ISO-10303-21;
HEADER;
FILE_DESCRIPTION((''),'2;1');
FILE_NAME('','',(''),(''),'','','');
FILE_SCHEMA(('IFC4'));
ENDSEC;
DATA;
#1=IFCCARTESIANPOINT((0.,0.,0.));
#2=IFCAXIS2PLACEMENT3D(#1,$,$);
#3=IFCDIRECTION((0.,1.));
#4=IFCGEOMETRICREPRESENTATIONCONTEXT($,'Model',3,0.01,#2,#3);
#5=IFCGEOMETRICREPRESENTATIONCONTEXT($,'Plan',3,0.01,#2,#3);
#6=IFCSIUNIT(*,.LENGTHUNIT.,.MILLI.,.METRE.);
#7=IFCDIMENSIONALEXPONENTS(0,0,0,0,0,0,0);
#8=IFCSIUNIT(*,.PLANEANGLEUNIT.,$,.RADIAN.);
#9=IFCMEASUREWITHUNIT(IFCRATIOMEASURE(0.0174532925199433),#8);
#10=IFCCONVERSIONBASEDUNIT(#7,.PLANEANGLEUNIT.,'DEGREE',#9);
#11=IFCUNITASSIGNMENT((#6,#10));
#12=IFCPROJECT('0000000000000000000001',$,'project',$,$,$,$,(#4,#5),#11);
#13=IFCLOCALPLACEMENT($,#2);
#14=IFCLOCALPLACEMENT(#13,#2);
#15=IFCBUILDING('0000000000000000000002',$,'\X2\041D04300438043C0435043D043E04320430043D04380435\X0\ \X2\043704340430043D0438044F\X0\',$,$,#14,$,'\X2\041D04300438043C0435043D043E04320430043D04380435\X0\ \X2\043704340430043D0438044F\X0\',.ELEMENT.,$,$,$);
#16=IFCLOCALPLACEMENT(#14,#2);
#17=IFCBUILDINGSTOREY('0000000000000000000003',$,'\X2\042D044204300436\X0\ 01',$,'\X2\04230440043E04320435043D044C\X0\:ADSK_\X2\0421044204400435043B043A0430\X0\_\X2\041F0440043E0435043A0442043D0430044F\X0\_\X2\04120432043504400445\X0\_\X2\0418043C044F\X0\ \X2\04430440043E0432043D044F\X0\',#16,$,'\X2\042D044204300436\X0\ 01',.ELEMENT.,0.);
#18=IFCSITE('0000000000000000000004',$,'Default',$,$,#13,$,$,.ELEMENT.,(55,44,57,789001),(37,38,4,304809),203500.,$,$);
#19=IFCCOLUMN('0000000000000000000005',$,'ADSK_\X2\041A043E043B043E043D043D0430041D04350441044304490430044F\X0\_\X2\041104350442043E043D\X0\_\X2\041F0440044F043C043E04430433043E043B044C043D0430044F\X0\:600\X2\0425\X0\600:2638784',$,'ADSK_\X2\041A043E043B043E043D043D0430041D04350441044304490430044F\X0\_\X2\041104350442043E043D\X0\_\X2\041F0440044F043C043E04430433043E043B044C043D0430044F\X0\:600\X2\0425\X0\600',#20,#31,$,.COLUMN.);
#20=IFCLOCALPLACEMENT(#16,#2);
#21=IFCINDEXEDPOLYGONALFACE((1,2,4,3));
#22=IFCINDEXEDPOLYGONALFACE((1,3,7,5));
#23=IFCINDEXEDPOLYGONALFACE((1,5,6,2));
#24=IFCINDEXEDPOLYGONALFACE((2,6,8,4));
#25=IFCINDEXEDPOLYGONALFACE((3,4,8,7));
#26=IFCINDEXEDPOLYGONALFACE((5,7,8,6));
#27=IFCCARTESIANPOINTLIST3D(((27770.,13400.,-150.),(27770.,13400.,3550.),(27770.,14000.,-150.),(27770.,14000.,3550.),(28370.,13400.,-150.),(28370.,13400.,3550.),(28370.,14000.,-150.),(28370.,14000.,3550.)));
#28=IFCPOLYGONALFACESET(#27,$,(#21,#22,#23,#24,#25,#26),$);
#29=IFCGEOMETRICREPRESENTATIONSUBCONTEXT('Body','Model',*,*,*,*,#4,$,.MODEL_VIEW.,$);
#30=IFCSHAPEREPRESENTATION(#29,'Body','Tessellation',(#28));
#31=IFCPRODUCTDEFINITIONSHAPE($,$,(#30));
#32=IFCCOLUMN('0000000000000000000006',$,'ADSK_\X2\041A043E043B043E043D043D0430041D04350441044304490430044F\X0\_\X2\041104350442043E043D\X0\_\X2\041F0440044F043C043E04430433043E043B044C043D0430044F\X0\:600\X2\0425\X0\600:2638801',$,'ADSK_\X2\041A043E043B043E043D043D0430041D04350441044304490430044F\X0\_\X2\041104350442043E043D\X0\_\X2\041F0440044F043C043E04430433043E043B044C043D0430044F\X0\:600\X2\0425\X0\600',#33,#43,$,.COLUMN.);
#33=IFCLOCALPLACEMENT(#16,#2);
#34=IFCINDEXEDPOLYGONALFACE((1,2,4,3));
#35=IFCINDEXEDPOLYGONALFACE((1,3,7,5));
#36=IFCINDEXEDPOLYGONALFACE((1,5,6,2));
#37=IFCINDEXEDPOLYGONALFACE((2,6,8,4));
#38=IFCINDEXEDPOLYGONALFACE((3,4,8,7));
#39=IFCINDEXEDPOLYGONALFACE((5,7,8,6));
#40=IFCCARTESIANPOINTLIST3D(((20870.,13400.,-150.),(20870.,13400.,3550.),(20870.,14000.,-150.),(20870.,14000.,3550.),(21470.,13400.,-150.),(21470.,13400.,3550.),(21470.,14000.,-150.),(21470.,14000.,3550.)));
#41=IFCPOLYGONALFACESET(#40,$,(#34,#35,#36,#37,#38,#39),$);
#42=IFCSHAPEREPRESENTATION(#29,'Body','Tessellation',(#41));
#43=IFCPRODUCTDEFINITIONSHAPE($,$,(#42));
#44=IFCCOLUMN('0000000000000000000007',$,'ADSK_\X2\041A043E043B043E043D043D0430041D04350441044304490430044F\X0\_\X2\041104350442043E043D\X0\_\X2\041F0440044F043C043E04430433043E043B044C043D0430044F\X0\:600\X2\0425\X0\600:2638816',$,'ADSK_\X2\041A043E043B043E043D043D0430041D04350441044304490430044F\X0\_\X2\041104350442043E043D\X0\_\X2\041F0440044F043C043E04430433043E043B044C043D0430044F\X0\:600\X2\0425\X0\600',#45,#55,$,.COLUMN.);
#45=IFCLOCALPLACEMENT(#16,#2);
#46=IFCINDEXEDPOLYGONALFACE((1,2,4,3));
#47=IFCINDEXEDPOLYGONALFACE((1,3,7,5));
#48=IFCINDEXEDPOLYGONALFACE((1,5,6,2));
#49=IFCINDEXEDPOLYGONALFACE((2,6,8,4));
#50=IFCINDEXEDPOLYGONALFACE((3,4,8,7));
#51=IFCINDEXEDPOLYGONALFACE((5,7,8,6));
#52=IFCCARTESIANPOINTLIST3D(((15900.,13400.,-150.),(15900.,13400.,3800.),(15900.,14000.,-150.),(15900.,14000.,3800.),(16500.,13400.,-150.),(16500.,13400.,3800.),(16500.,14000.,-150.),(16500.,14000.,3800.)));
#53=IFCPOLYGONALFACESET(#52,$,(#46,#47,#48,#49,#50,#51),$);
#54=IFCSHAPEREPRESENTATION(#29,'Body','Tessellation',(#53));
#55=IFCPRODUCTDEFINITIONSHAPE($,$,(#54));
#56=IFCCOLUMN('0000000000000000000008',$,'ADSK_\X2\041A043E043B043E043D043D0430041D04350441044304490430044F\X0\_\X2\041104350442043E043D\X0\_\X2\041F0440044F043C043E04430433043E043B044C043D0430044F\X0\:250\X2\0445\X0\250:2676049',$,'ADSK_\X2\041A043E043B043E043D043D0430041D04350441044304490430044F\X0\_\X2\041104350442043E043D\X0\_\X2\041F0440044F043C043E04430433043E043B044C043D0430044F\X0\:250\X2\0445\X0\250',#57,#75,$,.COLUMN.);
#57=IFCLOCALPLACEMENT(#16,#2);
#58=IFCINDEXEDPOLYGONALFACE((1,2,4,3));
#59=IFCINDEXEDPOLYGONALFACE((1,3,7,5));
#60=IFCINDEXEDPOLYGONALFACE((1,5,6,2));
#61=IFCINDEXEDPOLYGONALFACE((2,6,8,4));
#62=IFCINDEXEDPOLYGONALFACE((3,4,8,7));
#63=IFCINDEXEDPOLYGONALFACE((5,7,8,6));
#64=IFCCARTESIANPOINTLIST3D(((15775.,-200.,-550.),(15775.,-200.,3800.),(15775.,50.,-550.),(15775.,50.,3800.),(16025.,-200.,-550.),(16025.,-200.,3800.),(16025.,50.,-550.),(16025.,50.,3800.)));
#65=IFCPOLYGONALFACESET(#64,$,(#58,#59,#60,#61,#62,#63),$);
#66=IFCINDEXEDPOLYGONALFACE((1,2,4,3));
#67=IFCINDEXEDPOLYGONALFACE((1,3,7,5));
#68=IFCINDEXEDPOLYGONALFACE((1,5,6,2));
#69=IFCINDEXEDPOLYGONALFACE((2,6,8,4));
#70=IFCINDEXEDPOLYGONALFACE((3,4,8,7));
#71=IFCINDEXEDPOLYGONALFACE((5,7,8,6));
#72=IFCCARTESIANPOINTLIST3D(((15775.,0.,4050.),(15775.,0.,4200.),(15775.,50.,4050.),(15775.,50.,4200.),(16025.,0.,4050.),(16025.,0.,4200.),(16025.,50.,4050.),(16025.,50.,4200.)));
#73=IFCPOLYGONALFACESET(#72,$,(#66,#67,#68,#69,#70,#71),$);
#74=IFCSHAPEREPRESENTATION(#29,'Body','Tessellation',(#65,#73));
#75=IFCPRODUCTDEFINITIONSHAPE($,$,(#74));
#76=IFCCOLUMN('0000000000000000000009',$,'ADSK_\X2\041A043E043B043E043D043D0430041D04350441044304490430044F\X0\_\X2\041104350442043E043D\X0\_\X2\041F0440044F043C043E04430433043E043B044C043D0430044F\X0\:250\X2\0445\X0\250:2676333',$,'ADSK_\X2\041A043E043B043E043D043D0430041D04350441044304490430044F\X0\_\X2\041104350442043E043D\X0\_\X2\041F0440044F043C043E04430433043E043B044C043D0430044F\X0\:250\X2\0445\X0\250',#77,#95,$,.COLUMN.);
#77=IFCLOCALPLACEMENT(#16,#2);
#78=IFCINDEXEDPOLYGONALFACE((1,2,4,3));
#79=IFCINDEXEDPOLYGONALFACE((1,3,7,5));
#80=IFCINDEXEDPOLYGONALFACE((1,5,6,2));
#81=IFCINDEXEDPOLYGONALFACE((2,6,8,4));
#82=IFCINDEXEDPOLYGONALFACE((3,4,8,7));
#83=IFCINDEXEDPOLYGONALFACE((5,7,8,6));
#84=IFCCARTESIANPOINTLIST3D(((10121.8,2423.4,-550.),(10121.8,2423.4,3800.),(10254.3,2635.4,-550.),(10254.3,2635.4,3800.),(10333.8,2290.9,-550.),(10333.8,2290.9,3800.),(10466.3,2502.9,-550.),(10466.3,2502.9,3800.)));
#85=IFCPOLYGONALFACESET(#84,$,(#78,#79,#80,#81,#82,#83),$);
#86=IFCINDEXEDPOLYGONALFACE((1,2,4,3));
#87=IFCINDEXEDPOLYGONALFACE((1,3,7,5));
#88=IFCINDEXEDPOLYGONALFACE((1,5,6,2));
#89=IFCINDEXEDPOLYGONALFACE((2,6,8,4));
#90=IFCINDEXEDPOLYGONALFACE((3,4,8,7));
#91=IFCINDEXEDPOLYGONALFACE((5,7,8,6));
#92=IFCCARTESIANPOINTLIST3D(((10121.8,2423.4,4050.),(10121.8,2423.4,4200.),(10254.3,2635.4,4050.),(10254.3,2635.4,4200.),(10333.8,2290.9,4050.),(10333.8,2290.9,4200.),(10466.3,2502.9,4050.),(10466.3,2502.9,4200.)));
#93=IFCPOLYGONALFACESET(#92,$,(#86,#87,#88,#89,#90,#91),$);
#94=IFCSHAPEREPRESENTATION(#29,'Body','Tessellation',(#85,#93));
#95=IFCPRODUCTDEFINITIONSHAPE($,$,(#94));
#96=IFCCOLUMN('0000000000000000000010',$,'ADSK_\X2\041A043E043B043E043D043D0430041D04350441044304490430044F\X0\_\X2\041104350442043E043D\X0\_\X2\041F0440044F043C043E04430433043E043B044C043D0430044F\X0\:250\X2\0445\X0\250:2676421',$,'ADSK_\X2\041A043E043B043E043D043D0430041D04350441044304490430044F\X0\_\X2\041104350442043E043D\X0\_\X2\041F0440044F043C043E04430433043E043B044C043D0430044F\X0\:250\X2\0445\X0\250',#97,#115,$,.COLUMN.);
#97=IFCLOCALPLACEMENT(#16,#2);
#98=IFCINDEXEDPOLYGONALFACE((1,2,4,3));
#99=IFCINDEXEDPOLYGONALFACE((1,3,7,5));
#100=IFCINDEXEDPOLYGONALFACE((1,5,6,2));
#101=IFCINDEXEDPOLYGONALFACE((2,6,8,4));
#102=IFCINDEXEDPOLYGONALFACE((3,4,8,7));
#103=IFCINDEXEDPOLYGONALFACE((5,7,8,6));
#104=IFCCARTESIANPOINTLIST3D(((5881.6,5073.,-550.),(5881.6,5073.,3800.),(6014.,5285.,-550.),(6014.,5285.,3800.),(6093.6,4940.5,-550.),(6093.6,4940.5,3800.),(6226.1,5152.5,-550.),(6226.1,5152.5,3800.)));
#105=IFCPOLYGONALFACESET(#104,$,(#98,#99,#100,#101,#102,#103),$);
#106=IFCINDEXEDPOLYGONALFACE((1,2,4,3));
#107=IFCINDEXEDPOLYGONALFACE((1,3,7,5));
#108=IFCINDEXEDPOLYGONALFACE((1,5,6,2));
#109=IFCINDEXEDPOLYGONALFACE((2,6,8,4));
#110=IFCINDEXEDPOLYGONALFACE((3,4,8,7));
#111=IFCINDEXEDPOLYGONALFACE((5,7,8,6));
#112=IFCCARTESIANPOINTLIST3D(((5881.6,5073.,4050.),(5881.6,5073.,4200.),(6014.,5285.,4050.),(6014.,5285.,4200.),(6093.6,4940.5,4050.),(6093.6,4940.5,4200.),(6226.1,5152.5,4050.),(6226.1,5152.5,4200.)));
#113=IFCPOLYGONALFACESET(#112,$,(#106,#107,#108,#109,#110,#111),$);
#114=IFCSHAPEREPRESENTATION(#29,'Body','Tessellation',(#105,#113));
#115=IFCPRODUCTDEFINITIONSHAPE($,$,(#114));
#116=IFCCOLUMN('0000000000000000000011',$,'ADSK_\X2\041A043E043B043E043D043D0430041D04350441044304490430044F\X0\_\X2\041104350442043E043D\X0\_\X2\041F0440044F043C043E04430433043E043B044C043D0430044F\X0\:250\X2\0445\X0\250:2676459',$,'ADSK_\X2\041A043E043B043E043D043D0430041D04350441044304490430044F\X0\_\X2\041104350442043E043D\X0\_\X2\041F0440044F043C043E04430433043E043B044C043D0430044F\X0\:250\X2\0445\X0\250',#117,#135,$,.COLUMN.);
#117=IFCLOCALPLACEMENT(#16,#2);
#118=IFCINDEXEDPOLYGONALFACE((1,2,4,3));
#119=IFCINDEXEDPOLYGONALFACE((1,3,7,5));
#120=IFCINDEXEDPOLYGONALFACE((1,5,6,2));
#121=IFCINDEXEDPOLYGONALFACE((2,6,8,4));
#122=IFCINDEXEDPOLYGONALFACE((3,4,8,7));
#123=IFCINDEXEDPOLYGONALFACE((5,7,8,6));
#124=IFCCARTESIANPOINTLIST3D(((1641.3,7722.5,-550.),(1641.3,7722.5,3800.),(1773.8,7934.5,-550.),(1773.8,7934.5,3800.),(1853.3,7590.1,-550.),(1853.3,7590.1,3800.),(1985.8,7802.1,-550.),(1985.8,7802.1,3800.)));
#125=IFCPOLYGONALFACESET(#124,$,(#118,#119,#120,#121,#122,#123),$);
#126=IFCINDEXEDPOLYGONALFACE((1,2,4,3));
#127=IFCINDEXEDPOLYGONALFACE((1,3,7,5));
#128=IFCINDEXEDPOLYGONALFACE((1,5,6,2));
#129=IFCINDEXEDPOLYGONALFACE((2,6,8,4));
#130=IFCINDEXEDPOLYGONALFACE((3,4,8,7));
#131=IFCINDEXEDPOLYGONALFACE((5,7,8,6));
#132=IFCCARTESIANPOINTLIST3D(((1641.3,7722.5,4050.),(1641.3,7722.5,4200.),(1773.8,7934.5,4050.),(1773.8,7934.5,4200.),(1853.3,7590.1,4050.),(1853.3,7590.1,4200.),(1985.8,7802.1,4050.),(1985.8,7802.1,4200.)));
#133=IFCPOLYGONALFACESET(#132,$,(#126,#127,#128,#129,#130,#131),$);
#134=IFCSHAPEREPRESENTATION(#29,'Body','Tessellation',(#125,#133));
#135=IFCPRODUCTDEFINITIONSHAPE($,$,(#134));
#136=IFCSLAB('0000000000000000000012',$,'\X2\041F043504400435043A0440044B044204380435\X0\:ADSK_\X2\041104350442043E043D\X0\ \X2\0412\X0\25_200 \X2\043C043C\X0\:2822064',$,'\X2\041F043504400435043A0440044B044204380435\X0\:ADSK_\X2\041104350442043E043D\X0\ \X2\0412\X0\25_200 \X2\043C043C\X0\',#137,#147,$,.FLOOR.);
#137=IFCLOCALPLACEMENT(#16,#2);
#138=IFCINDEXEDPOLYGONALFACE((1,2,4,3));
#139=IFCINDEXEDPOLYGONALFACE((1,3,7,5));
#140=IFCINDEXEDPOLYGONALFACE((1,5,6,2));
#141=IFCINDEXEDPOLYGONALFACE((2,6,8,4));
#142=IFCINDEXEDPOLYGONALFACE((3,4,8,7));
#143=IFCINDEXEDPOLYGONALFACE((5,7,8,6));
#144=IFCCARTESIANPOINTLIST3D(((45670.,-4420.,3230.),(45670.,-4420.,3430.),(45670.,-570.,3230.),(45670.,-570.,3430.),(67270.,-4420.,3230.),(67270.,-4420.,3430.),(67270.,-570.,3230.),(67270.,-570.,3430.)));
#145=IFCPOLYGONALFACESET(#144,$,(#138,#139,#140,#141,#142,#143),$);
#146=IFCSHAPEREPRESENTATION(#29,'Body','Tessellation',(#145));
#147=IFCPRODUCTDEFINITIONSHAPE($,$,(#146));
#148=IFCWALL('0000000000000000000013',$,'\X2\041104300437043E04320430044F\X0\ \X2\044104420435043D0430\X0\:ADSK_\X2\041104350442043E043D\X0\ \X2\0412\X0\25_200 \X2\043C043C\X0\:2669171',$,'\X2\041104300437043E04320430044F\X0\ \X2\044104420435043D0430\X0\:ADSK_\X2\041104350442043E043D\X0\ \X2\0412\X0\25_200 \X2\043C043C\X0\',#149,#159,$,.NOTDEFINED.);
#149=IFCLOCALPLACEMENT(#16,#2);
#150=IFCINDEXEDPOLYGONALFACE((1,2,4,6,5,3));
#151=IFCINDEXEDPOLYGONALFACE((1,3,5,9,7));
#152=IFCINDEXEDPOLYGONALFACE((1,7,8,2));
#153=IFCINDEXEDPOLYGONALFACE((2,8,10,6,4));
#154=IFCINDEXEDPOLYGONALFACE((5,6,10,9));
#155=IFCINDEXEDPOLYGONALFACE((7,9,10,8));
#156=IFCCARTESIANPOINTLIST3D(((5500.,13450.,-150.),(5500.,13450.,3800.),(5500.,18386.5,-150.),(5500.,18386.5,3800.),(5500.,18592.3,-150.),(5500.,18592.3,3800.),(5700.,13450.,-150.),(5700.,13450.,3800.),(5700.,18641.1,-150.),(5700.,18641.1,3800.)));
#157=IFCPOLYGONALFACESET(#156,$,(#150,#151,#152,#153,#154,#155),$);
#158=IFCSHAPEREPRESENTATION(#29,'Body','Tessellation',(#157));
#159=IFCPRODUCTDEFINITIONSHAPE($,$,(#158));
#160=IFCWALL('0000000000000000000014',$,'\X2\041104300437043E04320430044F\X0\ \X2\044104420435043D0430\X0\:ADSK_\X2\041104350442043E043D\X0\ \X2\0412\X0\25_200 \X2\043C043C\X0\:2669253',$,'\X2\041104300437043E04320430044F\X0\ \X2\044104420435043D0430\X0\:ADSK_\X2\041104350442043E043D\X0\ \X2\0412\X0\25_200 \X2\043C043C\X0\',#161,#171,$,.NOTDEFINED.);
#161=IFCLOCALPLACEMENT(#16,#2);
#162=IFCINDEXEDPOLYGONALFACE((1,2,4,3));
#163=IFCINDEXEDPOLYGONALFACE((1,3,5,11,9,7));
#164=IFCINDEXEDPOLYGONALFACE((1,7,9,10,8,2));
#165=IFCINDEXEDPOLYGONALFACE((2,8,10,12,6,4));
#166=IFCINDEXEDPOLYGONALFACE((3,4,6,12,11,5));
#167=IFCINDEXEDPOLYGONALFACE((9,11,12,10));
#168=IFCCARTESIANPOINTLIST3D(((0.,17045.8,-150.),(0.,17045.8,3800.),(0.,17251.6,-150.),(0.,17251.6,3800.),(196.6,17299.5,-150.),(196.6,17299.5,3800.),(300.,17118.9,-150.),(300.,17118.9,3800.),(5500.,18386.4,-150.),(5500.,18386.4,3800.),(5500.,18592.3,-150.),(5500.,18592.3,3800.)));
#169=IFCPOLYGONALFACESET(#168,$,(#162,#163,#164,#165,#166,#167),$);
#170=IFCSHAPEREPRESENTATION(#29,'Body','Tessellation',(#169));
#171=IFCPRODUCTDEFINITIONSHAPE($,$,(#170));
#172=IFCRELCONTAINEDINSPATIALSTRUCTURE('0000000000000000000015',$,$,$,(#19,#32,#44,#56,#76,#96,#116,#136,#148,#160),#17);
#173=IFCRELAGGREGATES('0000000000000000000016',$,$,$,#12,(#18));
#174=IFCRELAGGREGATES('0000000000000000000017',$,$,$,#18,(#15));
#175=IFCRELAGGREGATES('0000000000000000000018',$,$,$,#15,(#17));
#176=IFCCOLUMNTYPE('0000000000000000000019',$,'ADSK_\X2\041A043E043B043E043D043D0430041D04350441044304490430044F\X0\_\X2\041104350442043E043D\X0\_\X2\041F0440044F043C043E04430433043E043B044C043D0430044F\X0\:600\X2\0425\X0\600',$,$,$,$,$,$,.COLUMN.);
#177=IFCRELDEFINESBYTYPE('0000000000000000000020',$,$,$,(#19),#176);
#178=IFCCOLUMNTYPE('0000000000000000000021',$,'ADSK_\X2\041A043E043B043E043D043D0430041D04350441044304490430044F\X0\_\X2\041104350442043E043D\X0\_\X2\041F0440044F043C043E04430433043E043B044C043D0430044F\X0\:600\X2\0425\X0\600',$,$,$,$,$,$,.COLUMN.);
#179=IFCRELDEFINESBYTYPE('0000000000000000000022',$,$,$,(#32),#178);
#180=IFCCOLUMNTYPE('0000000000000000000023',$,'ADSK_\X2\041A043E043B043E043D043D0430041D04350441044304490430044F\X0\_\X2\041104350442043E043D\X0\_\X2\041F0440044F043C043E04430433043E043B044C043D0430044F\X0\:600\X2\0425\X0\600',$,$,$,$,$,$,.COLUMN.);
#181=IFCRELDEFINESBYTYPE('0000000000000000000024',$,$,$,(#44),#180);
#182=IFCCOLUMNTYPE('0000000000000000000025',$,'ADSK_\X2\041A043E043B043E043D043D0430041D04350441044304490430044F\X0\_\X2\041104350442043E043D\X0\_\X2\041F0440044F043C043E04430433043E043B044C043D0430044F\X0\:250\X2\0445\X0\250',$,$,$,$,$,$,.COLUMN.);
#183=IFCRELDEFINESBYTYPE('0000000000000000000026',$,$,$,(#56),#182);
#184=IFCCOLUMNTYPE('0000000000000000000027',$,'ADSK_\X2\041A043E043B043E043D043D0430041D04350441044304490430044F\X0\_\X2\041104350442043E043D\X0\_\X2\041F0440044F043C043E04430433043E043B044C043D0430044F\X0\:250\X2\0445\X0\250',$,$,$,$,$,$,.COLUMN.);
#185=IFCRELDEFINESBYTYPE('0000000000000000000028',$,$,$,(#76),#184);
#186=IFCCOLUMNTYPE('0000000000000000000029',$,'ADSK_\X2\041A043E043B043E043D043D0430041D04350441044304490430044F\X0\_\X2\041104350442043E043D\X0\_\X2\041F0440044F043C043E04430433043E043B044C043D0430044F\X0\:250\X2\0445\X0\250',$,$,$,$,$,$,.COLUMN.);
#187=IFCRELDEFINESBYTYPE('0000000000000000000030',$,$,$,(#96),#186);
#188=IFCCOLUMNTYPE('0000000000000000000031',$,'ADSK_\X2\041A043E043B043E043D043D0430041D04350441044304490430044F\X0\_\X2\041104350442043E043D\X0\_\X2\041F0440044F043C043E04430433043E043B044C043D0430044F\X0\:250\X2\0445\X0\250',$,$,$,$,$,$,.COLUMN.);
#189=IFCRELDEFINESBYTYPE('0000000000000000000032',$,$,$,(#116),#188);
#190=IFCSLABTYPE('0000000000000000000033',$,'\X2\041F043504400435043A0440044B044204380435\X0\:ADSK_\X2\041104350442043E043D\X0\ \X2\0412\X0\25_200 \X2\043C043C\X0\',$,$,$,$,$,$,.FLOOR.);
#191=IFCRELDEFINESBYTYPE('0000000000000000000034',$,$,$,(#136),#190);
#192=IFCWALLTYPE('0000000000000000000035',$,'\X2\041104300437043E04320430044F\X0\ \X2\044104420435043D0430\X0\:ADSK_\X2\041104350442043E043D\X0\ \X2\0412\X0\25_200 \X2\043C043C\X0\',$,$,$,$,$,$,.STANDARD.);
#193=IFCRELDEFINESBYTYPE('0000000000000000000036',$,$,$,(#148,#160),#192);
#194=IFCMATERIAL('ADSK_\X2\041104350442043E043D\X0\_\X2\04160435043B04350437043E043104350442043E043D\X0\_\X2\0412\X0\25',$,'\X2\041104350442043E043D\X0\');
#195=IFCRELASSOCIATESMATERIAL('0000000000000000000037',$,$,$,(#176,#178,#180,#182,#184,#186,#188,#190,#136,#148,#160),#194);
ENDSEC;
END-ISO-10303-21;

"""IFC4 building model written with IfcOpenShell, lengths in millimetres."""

from ifc_helpers import new_model, entity, si_unit, converted_unit, direction, frame, origin, place, context, subcontext, project, spatial, indexed_curve, outline, extrude, source, transform, mapped, material, type_object, type_shapes, element, save


model = new_model("IFC4")

# Units and contexts
model_context = context("Model", 3, precision=0.01, world=origin(), true_north=direction((0.0, 1.0)))
plan_context = context("Plan", 3, precision=0.01, world=origin(), true_north=direction((0.0, 1.0)))
body_context = subcontext(model_context, "Body", "Model", "MODEL_VIEW")
ifc_project = project(units=[si_unit("LENGTHUNIT", "METRE", prefix="MILLI"), converted_unit("PLANEANGLEUNIT", "DEGREE", entity("IfcRatioMeasure", 0.0174532925199433), si_unit("PLANEANGLEUNIT", "RADIAN"), dimensions=[0, 0, 0, 0, 0, 0, 0])], contexts=[model_context, plan_context])

# Site, building, storey
site_placement = place(None, origin())
site = spatial("IfcSite", under=ifc_project, at=site_placement, Name="Default", CompositionType="ELEMENT", RefLatitude=(55, 44, 57, 789001), RefLongitude=(37, 38, 4, 304809), RefElevation=203500.0)
building_placement = place(site_placement, origin())
building = spatial("IfcBuilding", under=site, at=building_placement, Name="Наименование здания", LongName="Наименование здания", CompositionType="ELEMENT")
storey_placement = place(building_placement, origin())
storey = spatial("IfcBuildingStorey", under=building, at=storey_placement, Name="Этаж 01", ObjectType="Уровень:ADSK_Стрелка_Проектная_Вверх_Имя уровня", LongName="Этаж 01", CompositionType="ELEMENT", Elevation=0.0)

# Columns
ifc_material = material(Name="ADSK_Бетон_Железобетон_В25", Category="Бетон")
placement = place(storey_placement, origin())
column_type_1 = type_object("IfcColumnType", Name="ADSK_КолоннаНесущая_Бетон_Прямоугольная:600Х600", PredefinedType="COLUMN", material=ifc_material)
shared_shape_1 = source(origin(), body_context, "Body", "SweptSolid", [
    extrude(outline(indexed_curve([(-300.0, -300.0), (300.0, -300.0), (300.0, 300.0), (-300.0, 300.0), (-300.0, -300.0)], self_intersect=False)), frame((28070.0, 13700.0, -150.0), z_axis=(0.0, 0.0, 1.0), x_axis=(0.0, -1.0, 0.0)), (0.0, 0.0, 1.0), 3700.0),
])
type_shapes(column_type_1, [shared_shape_1])
element("IfcColumn", 1, at=placement, inside=storey, type_object=column_type_1, Name="ADSK_КолоннаНесущая_Бетон_Прямоугольная:600Х600:2638784", ObjectType="ADSK_КолоннаНесущая_Бетон_Прямоугольная:600Х600", PredefinedType="COLUMN", context=body_context, shape_type="MappedRepresentation", body=[
    mapped(shared_shape_1, transform((0.0, 0.0, 0.0), scale=1.0)),
])
column_type_2 = type_object("IfcColumnType", Name="ADSK_КолоннаНесущая_Бетон_Прямоугольная:600Х600", PredefinedType="COLUMN", material=ifc_material)
shared_shape_2 = source(origin(), body_context, "Body", "SweptSolid", [
    extrude(outline(indexed_curve([(-300.0, -300.0), (300.0, -300.0), (300.0, 300.0), (-300.0, 300.0), (-300.0, -300.0)], self_intersect=False)), frame((21170.0, 13700.0, -150.0), z_axis=(0.0, 0.0, 1.0), x_axis=(0.0, -1.0, 0.0)), (0.0, 0.0, 1.0), 3700.0),
])
type_shapes(column_type_2, [shared_shape_2])
element("IfcColumn", 2, at=placement, inside=storey, type_object=column_type_2, Name="ADSK_КолоннаНесущая_Бетон_Прямоугольная:600Х600:2638801", ObjectType="ADSK_КолоннаНесущая_Бетон_Прямоугольная:600Х600", PredefinedType="COLUMN", context=body_context, shape_type="MappedRepresentation", body=[
    mapped(shared_shape_2, transform((0.0, 0.0, 0.0), scale=1.0)),
])
column_type_3 = type_object("IfcColumnType", Name="ADSK_КолоннаНесущая_Бетон_Прямоугольная:600Х600", PredefinedType="COLUMN", material=ifc_material)
shared_shape_3 = source(origin(), body_context, "Body", "SweptSolid", [
    extrude(outline(indexed_curve([(-300.0, -300.0), (300.0, -300.0), (300.0, 300.0), (-300.0, 300.0), (-300.0, -300.0)], self_intersect=False)), frame((16200.0, 13700.0, -150.0), z_axis=(0.0, 0.0, 1.0), x_axis=(0.0, -1.0, 0.0)), (0.0, 0.0, 1.0), 3950.0),
])
type_shapes(column_type_3, [shared_shape_3])
element("IfcColumn", 3, at=placement, inside=storey, type_object=column_type_3, Name="ADSK_КолоннаНесущая_Бетон_Прямоугольная:600Х600:2638816", ObjectType="ADSK_КолоннаНесущая_Бетон_Прямоугольная:600Х600", PredefinedType="COLUMN", context=body_context, shape_type="MappedRepresentation", body=[
    mapped(shared_shape_3, transform((0.0, 0.0, 0.0), scale=1.0)),
])
column_type_4 = type_object("IfcColumnType", Name="ADSK_КолоннаНесущая_Бетон_Прямоугольная:250х250", PredefinedType="COLUMN", material=ifc_material)
shared_shape_4 = source(origin(), body_context, "Body", "SweptSolid", [
    extrude(outline(indexed_curve([(-125.0, -125.0), (125.0, -125.0), (125.0, 125.0), (-125.0, 125.0), (-125.0, -125.0)], self_intersect=False)), frame((15900.0, -75.0, -550.0), z_axis=(0.0, 0.0, 1.0), x_axis=(0.0, -1.0, 0.0)), (0.0, 0.0, 1.0), 4350.0),
    extrude(outline(indexed_curve([(-25.0, -125.0), (25.0, -125.0), (25.0, 125.0), (-25.0, 125.0), (-25.0, -125.0)], self_intersect=False)), frame((15900.0, 25.0, 4050.0), z_axis=(0.0, 0.0, 1.0), x_axis=(0.0, -1.0, 0.0)), (0.0, 0.0, 1.0), 150.0),
])
type_shapes(column_type_4, [shared_shape_4])
element("IfcColumn", 4, at=placement, inside=storey, type_object=column_type_4, Name="ADSK_КолоннаНесущая_Бетон_Прямоугольная:250х250:2676049", ObjectType="ADSK_КолоннаНесущая_Бетон_Прямоугольная:250х250", PredefinedType="COLUMN", context=body_context, shape_type="MappedRepresentation", body=[
    mapped(shared_shape_4, transform((0.0, 0.0, 0.0), scale=1.0)),
])
column_type_5 = type_object("IfcColumnType", Name="ADSK_КолоннаНесущая_Бетон_Прямоугольная:250х250", PredefinedType="COLUMN", material=ifc_material)
shared_shape_5 = source(origin(), body_context, "Body", "SweptSolid", [
    extrude(outline(indexed_curve([(-125.0, -125.0), (125.0, -125.0), (125.0, 125.0), (-125.0, 125.0), (-125.0, -125.0)], self_intersect=False)), frame((10294.1, 2463.2, -550.0), z_axis=(0.0, 0.0, 1.0), x_axis=(-0.848053, 0.529912, 0.0)), (0.0, 0.0, 1.0), 4350.0),
    extrude(outline(indexed_curve([(-125.0, -125.0), (125.0, -125.0), (125.0, 125.0), (-125.0, 125.0), (-125.0, -125.0)], self_intersect=False)), frame((10294.1, 2463.2, 4050.0), z_axis=(0.0, 0.0, 1.0), x_axis=(-0.848053, 0.529912, 0.0)), (0.0, 0.0, 1.0), 150.0),
])
type_shapes(column_type_5, [shared_shape_5])
element("IfcColumn", 5, at=placement, inside=storey, type_object=column_type_5, Name="ADSK_КолоннаНесущая_Бетон_Прямоугольная:250х250:2676333", ObjectType="ADSK_КолоннаНесущая_Бетон_Прямоугольная:250х250", PredefinedType="COLUMN", context=body_context, shape_type="MappedRepresentation", body=[
    mapped(shared_shape_5, transform((0.0, 0.0, 0.0), scale=1.0)),
])
column_type_6 = type_object("IfcColumnType", Name="ADSK_КолоннаНесущая_Бетон_Прямоугольная:250х250", PredefinedType="COLUMN", material=ifc_material)
shared_shape_6 = source(origin(), body_context, "Body", "SweptSolid", [
    extrude(outline(indexed_curve([(-125.0, -125.0), (125.0, -125.0), (125.0, 125.0), (-125.0, 125.0), (-125.0, -125.0)], self_intersect=False)), frame((6053.8, 5112.7, -550.0), z_axis=(0.0, 0.0, 1.0), x_axis=(-0.848053, 0.529912, 0.0)), (0.0, 0.0, 1.0), 4350.0),
    extrude(outline(indexed_curve([(-125.0, -125.0), (125.0, -125.0), (125.0, 125.0), (-125.0, 125.0), (-125.0, -125.0)], self_intersect=False)), frame((6053.8, 5112.7, 4050.0), z_axis=(0.0, 0.0, 1.0), x_axis=(-0.848053, 0.529912, 0.0)), (0.0, 0.0, 1.0), 150.0),
])
type_shapes(column_type_6, [shared_shape_6])
element("IfcColumn", 6, at=placement, inside=storey, type_object=column_type_6, Name="ADSK_КолоннаНесущая_Бетон_Прямоугольная:250х250:2676421", ObjectType="ADSK_КолоннаНесущая_Бетон_Прямоугольная:250х250", PredefinedType="COLUMN", context=body_context, shape_type="MappedRepresentation", body=[
    mapped(shared_shape_6, transform((0.0, 0.0, 0.0), scale=1.0)),
])
column_type_7 = type_object("IfcColumnType", Name="ADSK_КолоннаНесущая_Бетон_Прямоугольная:250х250", PredefinedType="COLUMN", material=ifc_material)
shared_shape_7 = source(origin(), body_context, "Body", "SweptSolid", [
    extrude(outline(indexed_curve([(-125.0, -125.0), (125.0, -125.0), (125.0, 125.0), (-125.0, 125.0), (-125.0, -125.0)], self_intersect=False)), frame((1813.5, 7762.3, -550.0), z_axis=(0.0, 0.0, 1.0), x_axis=(-0.848053, 0.529912, 0.0)), (0.0, 0.0, 1.0), 4350.0),
    extrude(outline(indexed_curve([(-125.0, -125.0), (125.0, -125.0), (125.0, 125.0), (-125.0, 125.0), (-125.0, -125.0)], self_intersect=False)), frame((1813.5, 7762.3, 4050.0), z_axis=(0.0, 0.0, 1.0), x_axis=(-0.848053, 0.529912, 0.0)), (0.0, 0.0, 1.0), 150.0),
])
type_shapes(column_type_7, [shared_shape_7])
element("IfcColumn", 7, at=placement, inside=storey, type_object=column_type_7, Name="ADSK_КолоннаНесущая_Бетон_Прямоугольная:250х250:2676459", ObjectType="ADSK_КолоннаНесущая_Бетон_Прямоугольная:250х250", PredefinedType="COLUMN", context=body_context, shape_type="MappedRepresentation", body=[
    mapped(shared_shape_7, transform((0.0, 0.0, 0.0), scale=1.0)),
])

# Slab
slab_type = type_object("IfcSlabType", Name="Перекрытие:ADSK_Бетон В25_200 мм", PredefinedType="FLOOR", material=ifc_material)
element("IfcSlab", 8, at=placement, inside=storey, type_object=slab_type, material=ifc_material, Name="Перекрытие:ADSK_Бетон В25_200 мм:2822064", ObjectType="Перекрытие:ADSK_Бетон В25_200 мм", PredefinedType="FLOOR", context=body_context, shape_type="SweptSolid", body=[
    extrude(outline(indexed_curve([(-1925.0, -10800.0), (1925.0, -10800.0), (1925.0, 10800.0), (-1925.0, 10800.0), (-1925.0, -10800.0)], self_intersect=False)), frame((56470.0, -2495.0, 3430.0), z_axis=(0.0, 0.0, -1.0), x_axis=(0.0, 1.0, 0.0)), (0.0, 0.0, 1.0), 200.0),
])

# Walls
wall_type_1 = type_object("IfcWallType", Name="Базовая стена:ADSK_Бетон В25_200 мм", PredefinedType="STANDARD")
wall_1_placement = place(storey_placement, frame((5600.0, 18641.1, -150.0), z_axis=(0.0, 0.0, 1.0), x_axis=(0.0, -1.0, 0.0)))
element("IfcWall", 9, at=wall_1_placement, inside=storey, type_object=wall_type_1, material=ifc_material, Name="Базовая стена:ADSK_Бетон В25_200 мм:2669171", ObjectType="Базовая стена:ADSK_Бетон В25_200 мм", PredefinedType="NOTDEFINED", context=body_context, shape_type="SweptSolid", body=[
    extrude(outline(indexed_curve([(5191.1, -100.0), (5191.1, 100.0), (0.0, 100.0), (48.8, -100.0), (254.6, -100.0), (5191.1, -100.0)], self_intersect=False)), origin(), (0.0, 0.0, 1.0), 3950.0),
])
wall_2_placement = place(storey_placement, frame((5523.7, 18495.2, -150.0), z_axis=(0.0, 0.0, 1.0), x_axis=(-0.971552, -0.236826, 0.0)))
element("IfcWall", 10, at=wall_2_placement, inside=storey, type_object=wall_type_1, material=ifc_material, Name="Базовая стена:ADSK_Бетон В25_200 мм:2669253", ObjectType="Базовая стена:ADSK_Бетон В25_200 мм", PredefinedType="NOTDEFINED", context=body_context, shape_type="SweptSolid", body=[
    extrude(outline(indexed_curve([(5661.0, -100.0), (5709.8, 100.0), (5401.0, 100.0), (48.8, 100.0), (0.0, -100.0), (5458.7, -100.0), (5661.0, -100.0)], self_intersect=False)), origin(), (0.0, 0.0, 1.0), 3950.0),
])

save(model, "model.ifc")
